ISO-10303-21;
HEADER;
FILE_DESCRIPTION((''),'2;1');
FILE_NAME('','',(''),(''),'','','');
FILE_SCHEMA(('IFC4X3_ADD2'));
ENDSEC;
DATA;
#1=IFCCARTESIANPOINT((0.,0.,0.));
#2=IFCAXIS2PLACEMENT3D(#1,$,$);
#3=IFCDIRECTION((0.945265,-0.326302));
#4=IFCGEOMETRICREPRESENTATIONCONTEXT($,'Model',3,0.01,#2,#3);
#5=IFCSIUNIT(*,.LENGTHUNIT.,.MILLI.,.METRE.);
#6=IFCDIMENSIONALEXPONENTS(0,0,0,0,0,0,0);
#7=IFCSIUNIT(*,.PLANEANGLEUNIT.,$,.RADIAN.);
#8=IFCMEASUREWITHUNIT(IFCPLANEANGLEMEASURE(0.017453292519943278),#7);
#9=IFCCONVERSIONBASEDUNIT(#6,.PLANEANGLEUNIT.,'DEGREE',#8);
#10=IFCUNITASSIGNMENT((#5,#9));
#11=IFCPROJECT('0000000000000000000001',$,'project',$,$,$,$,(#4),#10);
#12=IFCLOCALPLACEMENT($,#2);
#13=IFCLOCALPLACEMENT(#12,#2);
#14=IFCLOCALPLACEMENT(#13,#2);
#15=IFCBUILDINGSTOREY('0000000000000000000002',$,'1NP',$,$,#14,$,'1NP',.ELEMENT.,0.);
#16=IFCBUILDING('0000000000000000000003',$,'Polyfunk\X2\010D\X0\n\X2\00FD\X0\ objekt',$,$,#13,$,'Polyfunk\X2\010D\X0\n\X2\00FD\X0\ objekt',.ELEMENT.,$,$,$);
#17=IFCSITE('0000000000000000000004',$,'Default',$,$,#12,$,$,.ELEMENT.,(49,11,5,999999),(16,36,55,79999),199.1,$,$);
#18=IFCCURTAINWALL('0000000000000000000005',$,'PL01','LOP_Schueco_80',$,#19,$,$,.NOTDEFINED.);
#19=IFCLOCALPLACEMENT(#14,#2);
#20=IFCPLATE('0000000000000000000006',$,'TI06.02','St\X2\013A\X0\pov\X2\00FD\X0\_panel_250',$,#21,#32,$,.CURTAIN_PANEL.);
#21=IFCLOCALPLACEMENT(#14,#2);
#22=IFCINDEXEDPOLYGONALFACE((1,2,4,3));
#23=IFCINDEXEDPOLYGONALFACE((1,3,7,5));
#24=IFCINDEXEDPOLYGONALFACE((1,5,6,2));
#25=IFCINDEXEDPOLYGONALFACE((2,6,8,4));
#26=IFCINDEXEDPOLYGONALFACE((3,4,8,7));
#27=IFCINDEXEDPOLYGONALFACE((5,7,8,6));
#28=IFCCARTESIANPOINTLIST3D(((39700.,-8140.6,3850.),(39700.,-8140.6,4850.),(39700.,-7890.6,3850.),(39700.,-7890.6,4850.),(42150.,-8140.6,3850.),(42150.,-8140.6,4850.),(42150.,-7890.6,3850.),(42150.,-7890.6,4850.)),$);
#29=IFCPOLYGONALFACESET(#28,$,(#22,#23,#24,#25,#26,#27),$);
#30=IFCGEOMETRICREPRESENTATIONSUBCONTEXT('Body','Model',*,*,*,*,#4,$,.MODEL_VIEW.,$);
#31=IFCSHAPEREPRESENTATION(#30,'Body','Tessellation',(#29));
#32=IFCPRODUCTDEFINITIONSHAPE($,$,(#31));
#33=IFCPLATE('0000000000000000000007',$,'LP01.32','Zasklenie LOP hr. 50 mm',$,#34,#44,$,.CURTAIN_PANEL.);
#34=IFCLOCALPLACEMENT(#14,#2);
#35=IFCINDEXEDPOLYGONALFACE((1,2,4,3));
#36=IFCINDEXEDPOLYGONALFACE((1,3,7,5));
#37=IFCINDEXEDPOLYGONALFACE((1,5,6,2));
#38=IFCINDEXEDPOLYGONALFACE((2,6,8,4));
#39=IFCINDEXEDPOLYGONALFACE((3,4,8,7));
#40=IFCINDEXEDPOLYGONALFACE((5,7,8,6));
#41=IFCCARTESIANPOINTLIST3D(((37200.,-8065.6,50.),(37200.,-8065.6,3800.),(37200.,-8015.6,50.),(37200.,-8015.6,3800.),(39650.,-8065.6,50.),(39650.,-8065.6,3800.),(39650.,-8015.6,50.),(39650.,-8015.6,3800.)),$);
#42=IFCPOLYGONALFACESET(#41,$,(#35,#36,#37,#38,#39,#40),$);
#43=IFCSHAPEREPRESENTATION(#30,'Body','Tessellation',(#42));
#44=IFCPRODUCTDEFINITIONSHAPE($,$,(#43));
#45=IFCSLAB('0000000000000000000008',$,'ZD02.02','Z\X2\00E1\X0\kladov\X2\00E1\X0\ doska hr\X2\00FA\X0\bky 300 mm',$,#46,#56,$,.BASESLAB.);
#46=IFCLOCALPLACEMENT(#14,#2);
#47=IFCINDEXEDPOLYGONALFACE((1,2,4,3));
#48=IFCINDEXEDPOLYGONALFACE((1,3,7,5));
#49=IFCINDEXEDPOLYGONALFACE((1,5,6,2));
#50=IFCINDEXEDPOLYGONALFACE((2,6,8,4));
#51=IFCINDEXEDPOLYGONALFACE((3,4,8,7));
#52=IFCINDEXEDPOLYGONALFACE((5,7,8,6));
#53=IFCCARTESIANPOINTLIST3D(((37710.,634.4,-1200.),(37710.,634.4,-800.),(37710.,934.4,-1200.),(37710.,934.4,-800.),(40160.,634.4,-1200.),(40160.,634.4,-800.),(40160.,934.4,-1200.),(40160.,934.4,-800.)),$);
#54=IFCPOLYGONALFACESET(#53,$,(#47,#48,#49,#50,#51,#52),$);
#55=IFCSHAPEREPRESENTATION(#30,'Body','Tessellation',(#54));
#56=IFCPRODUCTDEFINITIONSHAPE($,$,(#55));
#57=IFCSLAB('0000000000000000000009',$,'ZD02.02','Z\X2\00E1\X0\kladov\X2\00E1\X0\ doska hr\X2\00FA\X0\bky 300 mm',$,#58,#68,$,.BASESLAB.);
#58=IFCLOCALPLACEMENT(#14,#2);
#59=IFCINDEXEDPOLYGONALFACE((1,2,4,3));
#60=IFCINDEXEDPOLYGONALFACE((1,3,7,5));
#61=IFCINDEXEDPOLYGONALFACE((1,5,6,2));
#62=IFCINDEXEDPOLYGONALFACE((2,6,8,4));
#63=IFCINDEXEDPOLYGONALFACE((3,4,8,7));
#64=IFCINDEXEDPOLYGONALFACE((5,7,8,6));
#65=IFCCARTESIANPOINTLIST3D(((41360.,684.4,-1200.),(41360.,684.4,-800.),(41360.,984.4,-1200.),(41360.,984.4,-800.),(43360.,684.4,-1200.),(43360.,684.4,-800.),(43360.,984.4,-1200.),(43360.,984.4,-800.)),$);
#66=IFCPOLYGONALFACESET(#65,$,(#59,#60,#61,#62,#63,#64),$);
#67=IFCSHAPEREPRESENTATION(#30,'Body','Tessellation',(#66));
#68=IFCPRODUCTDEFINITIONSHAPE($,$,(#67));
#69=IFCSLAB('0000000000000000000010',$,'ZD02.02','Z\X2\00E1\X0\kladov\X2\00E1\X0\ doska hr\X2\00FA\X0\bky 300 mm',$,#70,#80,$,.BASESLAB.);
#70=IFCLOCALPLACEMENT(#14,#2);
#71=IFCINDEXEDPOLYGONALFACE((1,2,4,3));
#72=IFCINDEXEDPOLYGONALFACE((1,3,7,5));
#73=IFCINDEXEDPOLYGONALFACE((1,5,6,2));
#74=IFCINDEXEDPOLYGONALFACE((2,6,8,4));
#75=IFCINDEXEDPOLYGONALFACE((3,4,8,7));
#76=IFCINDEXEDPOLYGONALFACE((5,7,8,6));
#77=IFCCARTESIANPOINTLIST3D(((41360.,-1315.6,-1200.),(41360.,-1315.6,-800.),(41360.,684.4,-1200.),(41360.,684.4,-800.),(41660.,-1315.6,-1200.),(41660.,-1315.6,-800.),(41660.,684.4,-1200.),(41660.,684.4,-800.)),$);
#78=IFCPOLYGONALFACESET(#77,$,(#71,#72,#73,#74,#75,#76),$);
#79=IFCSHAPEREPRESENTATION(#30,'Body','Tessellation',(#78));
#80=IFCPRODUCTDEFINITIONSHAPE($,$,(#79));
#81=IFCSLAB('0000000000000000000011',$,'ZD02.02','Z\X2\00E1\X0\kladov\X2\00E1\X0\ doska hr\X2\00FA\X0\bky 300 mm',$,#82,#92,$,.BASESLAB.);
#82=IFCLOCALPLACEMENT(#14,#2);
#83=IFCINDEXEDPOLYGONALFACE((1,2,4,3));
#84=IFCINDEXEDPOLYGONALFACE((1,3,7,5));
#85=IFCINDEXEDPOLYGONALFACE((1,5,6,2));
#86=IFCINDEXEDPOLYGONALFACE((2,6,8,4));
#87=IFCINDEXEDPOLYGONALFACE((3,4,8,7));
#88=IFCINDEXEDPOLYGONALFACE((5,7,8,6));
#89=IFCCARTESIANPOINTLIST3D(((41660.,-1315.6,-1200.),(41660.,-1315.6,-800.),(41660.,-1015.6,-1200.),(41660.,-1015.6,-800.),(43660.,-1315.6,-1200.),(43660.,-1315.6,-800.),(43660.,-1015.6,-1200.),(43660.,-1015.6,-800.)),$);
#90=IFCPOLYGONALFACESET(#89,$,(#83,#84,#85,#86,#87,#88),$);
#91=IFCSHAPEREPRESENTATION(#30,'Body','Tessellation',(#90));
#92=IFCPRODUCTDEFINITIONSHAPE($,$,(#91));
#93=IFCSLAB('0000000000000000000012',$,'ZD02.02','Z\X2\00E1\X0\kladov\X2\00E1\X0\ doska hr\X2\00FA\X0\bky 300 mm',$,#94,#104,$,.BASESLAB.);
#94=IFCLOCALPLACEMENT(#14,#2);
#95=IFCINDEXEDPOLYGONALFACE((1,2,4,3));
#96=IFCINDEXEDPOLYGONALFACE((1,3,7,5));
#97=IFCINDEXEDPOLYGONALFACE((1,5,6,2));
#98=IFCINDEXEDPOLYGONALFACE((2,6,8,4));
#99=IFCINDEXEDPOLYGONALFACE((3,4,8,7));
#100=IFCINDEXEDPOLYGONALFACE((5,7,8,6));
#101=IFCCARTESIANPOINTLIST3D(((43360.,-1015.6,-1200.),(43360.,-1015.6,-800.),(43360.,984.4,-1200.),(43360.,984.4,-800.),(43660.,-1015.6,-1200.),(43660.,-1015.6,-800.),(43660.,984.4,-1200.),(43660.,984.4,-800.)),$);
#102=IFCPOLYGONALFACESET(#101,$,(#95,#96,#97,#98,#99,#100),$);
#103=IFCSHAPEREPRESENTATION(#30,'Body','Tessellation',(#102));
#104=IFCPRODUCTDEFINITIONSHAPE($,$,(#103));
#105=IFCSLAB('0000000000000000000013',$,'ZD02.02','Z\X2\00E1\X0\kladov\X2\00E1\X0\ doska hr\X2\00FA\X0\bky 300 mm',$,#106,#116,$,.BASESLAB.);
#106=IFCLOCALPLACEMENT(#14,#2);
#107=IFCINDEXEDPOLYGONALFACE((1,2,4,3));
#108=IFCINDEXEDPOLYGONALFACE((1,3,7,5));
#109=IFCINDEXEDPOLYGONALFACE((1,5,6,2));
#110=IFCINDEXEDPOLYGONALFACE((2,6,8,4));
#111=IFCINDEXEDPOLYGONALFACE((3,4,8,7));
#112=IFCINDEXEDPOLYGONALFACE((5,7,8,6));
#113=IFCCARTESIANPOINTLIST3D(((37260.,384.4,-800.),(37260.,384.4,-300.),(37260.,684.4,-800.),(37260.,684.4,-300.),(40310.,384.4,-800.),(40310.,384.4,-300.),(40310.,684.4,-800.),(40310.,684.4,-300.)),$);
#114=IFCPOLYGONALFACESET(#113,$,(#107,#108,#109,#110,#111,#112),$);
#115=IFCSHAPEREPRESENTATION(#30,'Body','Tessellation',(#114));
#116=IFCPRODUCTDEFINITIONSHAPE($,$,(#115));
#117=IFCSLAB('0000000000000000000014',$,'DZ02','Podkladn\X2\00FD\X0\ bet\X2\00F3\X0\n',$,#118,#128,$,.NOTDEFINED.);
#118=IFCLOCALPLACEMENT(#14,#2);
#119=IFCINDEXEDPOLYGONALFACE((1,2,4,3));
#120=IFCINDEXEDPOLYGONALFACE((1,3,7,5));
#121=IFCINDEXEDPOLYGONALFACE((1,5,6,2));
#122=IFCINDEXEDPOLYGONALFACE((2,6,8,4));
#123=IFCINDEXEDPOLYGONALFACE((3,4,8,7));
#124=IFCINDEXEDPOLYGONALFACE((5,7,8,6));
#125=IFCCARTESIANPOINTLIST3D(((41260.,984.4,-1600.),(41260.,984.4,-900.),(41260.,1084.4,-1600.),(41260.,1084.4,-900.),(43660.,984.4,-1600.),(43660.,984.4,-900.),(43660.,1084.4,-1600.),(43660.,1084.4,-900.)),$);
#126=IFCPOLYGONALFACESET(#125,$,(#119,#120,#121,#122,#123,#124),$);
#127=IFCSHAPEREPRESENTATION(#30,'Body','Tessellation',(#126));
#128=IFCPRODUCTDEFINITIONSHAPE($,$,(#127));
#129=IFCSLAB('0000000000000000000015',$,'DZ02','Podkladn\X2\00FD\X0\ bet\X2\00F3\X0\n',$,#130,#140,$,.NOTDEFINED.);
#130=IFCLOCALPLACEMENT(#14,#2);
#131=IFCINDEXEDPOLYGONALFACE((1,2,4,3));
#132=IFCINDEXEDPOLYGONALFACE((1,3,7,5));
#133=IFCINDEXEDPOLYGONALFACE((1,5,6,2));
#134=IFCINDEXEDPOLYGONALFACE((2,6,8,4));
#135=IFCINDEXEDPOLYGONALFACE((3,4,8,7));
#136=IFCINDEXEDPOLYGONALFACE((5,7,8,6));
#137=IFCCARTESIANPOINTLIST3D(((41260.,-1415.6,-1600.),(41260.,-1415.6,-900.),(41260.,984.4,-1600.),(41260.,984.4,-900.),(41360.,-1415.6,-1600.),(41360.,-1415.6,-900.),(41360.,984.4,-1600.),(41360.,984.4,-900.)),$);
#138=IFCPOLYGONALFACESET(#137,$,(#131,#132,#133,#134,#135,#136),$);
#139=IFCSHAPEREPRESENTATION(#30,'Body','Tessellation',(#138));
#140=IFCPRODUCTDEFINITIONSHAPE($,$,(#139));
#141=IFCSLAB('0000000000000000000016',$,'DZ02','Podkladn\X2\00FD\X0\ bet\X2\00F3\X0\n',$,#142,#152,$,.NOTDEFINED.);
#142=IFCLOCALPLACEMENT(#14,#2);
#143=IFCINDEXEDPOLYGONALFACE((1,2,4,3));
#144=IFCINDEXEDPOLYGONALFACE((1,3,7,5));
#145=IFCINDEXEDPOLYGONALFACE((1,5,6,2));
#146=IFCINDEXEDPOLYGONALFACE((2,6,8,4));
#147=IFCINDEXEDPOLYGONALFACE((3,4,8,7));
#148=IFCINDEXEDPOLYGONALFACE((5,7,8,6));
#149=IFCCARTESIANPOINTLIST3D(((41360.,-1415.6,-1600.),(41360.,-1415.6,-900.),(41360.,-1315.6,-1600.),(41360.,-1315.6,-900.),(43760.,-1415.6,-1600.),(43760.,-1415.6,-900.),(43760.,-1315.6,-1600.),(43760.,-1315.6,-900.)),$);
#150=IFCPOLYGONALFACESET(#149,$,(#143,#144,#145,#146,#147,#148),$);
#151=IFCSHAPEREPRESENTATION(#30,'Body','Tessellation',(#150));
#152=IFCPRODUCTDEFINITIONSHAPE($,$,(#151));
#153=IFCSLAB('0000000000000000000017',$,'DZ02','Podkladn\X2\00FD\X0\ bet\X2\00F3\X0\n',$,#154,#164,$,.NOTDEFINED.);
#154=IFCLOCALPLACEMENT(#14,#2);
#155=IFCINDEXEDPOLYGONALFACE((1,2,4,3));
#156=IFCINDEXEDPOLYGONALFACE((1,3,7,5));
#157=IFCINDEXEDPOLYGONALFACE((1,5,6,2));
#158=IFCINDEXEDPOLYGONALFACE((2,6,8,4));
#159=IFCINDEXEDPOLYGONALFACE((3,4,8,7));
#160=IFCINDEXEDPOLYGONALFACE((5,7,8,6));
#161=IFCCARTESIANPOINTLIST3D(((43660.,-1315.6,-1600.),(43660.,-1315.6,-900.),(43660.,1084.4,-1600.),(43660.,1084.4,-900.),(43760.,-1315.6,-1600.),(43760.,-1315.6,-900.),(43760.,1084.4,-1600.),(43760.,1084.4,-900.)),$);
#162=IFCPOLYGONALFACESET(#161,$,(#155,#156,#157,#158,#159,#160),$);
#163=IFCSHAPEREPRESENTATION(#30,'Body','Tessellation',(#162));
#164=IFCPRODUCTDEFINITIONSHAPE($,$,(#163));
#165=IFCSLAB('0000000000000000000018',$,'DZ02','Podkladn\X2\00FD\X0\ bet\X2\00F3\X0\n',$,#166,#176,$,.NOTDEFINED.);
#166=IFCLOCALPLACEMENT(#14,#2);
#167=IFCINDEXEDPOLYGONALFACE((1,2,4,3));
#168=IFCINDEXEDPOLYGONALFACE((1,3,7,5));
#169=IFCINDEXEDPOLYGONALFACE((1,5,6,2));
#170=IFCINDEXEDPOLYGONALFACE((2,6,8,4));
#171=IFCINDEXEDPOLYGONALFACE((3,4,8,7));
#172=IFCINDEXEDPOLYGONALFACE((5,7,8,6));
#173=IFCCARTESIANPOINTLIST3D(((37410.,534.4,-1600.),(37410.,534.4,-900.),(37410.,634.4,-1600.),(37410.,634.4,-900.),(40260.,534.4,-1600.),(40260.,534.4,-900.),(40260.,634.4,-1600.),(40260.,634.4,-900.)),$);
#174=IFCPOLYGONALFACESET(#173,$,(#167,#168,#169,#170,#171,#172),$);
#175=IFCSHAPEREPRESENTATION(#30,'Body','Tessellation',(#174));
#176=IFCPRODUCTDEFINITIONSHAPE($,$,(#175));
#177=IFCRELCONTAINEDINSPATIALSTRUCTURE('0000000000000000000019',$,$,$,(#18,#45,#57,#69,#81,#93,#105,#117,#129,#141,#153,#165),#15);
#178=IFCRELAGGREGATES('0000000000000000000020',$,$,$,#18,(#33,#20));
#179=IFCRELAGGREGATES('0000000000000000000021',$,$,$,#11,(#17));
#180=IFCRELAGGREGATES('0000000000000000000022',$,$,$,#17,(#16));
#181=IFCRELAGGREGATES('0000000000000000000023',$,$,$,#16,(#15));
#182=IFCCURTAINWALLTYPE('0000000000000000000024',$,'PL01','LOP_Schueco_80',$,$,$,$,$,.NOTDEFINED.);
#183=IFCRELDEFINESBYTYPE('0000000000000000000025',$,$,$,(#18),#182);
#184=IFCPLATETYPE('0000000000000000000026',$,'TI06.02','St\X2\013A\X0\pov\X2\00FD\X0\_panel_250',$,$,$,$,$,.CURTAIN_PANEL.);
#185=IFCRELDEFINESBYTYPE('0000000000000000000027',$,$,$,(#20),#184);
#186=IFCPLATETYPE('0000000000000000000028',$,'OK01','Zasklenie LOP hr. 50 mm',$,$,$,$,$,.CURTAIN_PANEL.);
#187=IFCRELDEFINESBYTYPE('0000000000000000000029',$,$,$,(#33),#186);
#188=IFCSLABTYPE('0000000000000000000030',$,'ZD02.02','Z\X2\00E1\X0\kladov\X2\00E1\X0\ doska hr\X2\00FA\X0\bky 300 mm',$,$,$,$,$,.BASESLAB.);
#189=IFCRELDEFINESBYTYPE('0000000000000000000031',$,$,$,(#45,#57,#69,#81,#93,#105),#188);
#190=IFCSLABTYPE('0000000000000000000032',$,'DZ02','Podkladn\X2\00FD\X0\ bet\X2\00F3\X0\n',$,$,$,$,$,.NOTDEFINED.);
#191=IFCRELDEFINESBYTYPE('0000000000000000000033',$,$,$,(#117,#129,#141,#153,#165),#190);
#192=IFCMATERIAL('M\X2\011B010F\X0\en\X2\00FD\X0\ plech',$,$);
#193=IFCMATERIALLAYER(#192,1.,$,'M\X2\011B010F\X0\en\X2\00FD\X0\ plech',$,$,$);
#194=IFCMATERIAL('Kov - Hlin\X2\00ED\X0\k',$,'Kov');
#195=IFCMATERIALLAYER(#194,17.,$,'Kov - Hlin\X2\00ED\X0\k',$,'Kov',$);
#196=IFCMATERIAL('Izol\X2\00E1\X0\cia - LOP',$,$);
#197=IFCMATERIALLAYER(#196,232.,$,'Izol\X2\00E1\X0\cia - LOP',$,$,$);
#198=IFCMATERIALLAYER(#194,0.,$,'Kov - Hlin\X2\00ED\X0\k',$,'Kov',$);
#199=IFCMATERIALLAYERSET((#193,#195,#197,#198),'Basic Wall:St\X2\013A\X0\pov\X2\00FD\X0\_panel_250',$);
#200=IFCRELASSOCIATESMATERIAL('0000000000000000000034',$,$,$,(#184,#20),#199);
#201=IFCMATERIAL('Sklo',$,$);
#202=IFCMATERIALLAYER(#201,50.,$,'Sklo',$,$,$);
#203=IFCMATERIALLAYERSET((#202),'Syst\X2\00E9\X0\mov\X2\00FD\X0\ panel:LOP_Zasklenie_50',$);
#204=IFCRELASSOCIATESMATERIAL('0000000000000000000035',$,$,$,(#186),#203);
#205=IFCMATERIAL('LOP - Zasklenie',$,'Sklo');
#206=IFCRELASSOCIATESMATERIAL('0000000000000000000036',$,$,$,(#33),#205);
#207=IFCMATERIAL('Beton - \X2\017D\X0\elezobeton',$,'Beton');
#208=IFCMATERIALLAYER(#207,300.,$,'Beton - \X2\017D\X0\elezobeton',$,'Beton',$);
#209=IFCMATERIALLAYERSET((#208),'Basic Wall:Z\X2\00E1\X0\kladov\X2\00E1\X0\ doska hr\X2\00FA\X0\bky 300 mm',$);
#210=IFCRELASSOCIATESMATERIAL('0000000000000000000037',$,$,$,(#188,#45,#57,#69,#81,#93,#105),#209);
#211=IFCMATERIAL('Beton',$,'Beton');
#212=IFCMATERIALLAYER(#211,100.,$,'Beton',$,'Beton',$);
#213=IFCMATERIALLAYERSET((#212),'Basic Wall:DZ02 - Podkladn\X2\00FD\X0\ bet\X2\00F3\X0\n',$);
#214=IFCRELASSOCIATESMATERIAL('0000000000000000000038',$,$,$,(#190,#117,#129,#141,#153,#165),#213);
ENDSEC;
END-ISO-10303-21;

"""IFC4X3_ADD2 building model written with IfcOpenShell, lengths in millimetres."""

from ifc_helpers import new_model, entity, si_unit, converted_unit, direction, frame, frame_2d, origin, place, context, subcontext, project, spatial, rectangle, extrude, source, transform, mapped, material, layer, layer_set, layer_usage, type_object, type_shapes, element, aggregate, save


model = new_model("IFC4X3_ADD2")

# Units and contexts
model_context = context("Model", 3, precision=0.01, world=origin(), true_north=direction((0.945265, -0.326302)))
body_context = subcontext(model_context, "Body", "Model", "MODEL_VIEW")
ifc_project = project(units=[si_unit("LENGTHUNIT", "METRE", prefix="MILLI"), converted_unit("PLANEANGLEUNIT", "DEGREE", entity("IfcPlaneAngleMeasure", 0.017453292519943278), si_unit("PLANEANGLEUNIT", "RADIAN"), dimensions=[0, 0, 0, 0, 0, 0, 0])], contexts=[model_context])

# Site, building, storey
site_placement = place(None, origin())
site = spatial("IfcSite", under=ifc_project, at=site_placement, Name="Default", CompositionType="ELEMENT", RefLatitude=(49, 11, 5, 999999), RefLongitude=(16, 36, 55, 79999), RefElevation=199.1)
building_placement = place(site_placement, origin())
building = spatial("IfcBuilding", under=site, at=building_placement, Name="Polyfunkčný objekt", LongName="Polyfunkčný objekt", CompositionType="ELEMENT")
storey_placement = place(building_placement, origin())
storey = spatial("IfcBuildingStorey", under=building, at=storey_placement, Name="1NP", LongName="1NP", CompositionType="ELEMENT", Elevation=0.0)

# Curtain wall, plates
curtain_wall_type = type_object("IfcCurtainWallType", Name="PL01", Description="LOP_Schueco_80", PredefinedType="NOTDEFINED")
curtain_wall_placement = place(storey_placement, origin())
curtain_wall = element("IfcCurtainWall", 1, at=curtain_wall_placement, inside=storey, type_object=curtain_wall_type, Name="PL01", Description="LOP_Schueco_80", PredefinedType="NOTDEFINED")
ifc_material_1 = material(Name="Měďený plech")
ifc_layer_1 = layer(ifc_material_1, 1.0, Name="Měďený plech")
ifc_material_2 = material(Name="Kov - Hliník", Category="Kov")
ifc_layer_2 = layer(ifc_material_2, 17.0, Name="Kov - Hliník", Category="Kov")
ifc_material_3 = material(Name="Izolácia - LOP")
ifc_layer_3 = layer(ifc_material_3, 232.0, Name="Izolácia - LOP")
ifc_layer_4 = layer(ifc_material_2, 0.0, Name="Kov - Hliník", Category="Kov")
ifc_layer_set_1 = layer_set([ifc_layer_1, ifc_layer_2, ifc_layer_3, ifc_layer_4], Name="Basic Wall:Stĺpový_panel_250")
ifc_layer_usage = layer_usage(ifc_layer_set_1, "AXIS2", "POSITIVE", -125.0)
plate_type_1 = type_object("IfcPlateType", Name="TI06.02", Description="Stĺpový_panel_250", PredefinedType="CURTAIN_PANEL", material=ifc_layer_set_1)
plate_1_placement = place(storey_placement, frame((39700.0, -8015.6, 3850.0)))
plate_1 = element("IfcPlate", 2, at=plate_1_placement, type_object=plate_type_1, material=ifc_layer_usage, Name="TI06.02", Description="Stĺpový_panel_250", PredefinedType="CURTAIN_PANEL", context=body_context, shape_type="SweptSolid", body=[
    extrude(rectangle(XDim=250.0, YDim=2450.0, at=frame_2d((0.0, 0.0), x_axis=(1.0, 0.0))), frame((1225.0, 0.0, 0.0), z_axis=(0.0, 0.0, 1.0), x_axis=(0.0, 1.0, 0.0)), (0.0, 0.0, 1.0), 1000.0),
])
ifc_material_4 = material(Name="LOP - Zasklenie", Category="Sklo")
ifc_material_5 = material(Name="Sklo")
ifc_layer_5 = layer(ifc_material_5, 50.0, Name="Sklo")
ifc_layer_set_2 = layer_set([ifc_layer_5], Name="Systémový panel:LOP_Zasklenie_50")
plate_type_2 = type_object("IfcPlateType", Name="OK01", Description="Zasklenie LOP hr. 50 mm", PredefinedType="CURTAIN_PANEL", material=ifc_layer_set_2)
shared_shape_1 = source(origin(), body_context, "Body", "SweptSolid", [
    extrude(rectangle(XDim=3750.0, YDim=2450.0, at=frame_2d((-331.2, 0.0), x_axis=(1.0, 0.0))), frame((0.0, -50.0, 2206.2), z_axis=(0.0, 1.0, 0.0), x_axis=(0.0, 0.0, 1.0)), (0.0, 0.0, 1.0), 50.0),
])
type_shapes(plate_type_2, [shared_shape_1])
plate_2_placement = place(curtain_wall_placement, frame((38425.0, -8015.6, 50.0)))
plate_2 = element("IfcPlate", 3, at=plate_2_placement, type_object=plate_type_2, material=ifc_material_4, Name="LP01.32", Description="Zasklenie LOP hr. 50 mm", PredefinedType="CURTAIN_PANEL", context=body_context, shape_type="MappedRepresentation", body=[
    mapped(shared_shape_1, transform((0.0, 0.0, 0.0), scale=1.0)),
])
aggregate(curtain_wall, [plate_2, plate_1])

# Slabs
ifc_material_6 = material(Name="Beton - Železobeton", Category="Beton")
ifc_layer_6 = layer(ifc_material_6, 300.0, Name="Beton - Železobeton", Category="Beton")
ifc_layer_set_3 = layer_set([ifc_layer_6], Name="Basic Wall:Základová doska hrúbky 300 mm")
slab_type_1 = type_object("IfcSlabType", Name="ZD02.02", Description="Základová doska hrúbky 300 mm", PredefinedType="BASESLAB", material=ifc_layer_set_3)
slab_1_placement = place(storey_placement, frame((40160.0, 784.4, -1200.0), z_axis=(0.0, 0.0, 1.0), x_axis=(-1.0, 0.0, 0.0)))
element("IfcSlab", 4, at=slab_1_placement, inside=storey, type_object=slab_type_1, material=ifc_layer_set_3, Name="ZD02.02", Description="Základová doska hrúbky 300 mm", PredefinedType="BASESLAB", context=body_context, shape_type="SweptSolid", body=[
    extrude(rectangle(XDim=2450.0, YDim=300.0, at=frame_2d((1225.0, 0.0), x_axis=(-1.0, 0.0))), origin(), (0.0, 0.0, 1.0), 400.0),
])
slab_2_placement = place(storey_placement, frame((41360.0, 834.4, -1200.0)))
element("IfcSlab", 5, at=slab_2_placement, inside=storey, type_object=slab_type_1, material=ifc_layer_set_3, Name="ZD02.02", Description="Základová doska hrúbky 300 mm", PredefinedType="BASESLAB", context=body_context, shape_type="SweptSolid", body=[
    extrude(rectangle(XDim=2000.0, YDim=300.0, at=frame_2d((1000.0, 0.0), x_axis=(-1.0, 0.0))), origin(), (0.0, 0.0, 1.0), 400.0),
])
slab_3_placement = place(storey_placement, frame((41510.0, -1315.6, -1200.0), z_axis=(0.0, 0.0, 1.0), x_axis=(0.0, 1.0, 0.0)))
element("IfcSlab", 6, at=slab_3_placement, inside=storey, type_object=slab_type_1, material=ifc_layer_set_3, Name="ZD02.02", Description="Základová doska hrúbky 300 mm", PredefinedType="BASESLAB", context=body_context, shape_type="SweptSolid", body=[
    extrude(rectangle(XDim=2000.0, YDim=300.0, at=frame_2d((1000.0, 0.0), x_axis=(-1.0, 0.0))), origin(), (0.0, 0.0, 1.0), 400.0),
])
slab_4_placement = place(storey_placement, frame((43660.0, -1165.6, -1200.0), z_axis=(0.0, 0.0, 1.0), x_axis=(-1.0, 0.0, 0.0)))
element("IfcSlab", 7, at=slab_4_placement, inside=storey, type_object=slab_type_1, material=ifc_layer_set_3, Name="ZD02.02", Description="Základová doska hrúbky 300 mm", PredefinedType="BASESLAB", context=body_context, shape_type="SweptSolid", body=[
    extrude(rectangle(XDim=2000.0, YDim=300.0, at=frame_2d((1000.0, 0.0), x_axis=(-1.0, 0.0))), origin(), (0.0, 0.0, 1.0), 400.0),
])
slab_5_placement = place(storey_placement, frame((43510.0, 984.4, -1200.0), z_axis=(0.0, 0.0, 1.0), x_axis=(0.0, -1.0, 0.0)))
element("IfcSlab", 8, at=slab_5_placement, inside=storey, type_object=slab_type_1, material=ifc_layer_set_3, Name="ZD02.02", Description="Základová doska hrúbky 300 mm", PredefinedType="BASESLAB", context=body_context, shape_type="SweptSolid", body=[
    extrude(rectangle(XDim=2000.0, YDim=300.0, at=frame_2d((1000.0, 0.0), x_axis=(-1.0, 0.0))), origin(), (0.0, 0.0, 1.0), 400.0),
])
slab_6_placement = place(storey_placement, frame((40310.0, 534.4, -800.0), z_axis=(0.0, 0.0, 1.0), x_axis=(-1.0, 0.0, 0.0)))
element("IfcSlab", 9, at=slab_6_placement, inside=storey, type_object=slab_type_1, material=ifc_layer_set_3, Name="ZD02.02", Description="Základová doska hrúbky 300 mm", PredefinedType="BASESLAB", context=body_context, shape_type="SweptSolid", body=[
    extrude(rectangle(XDim=3050.0, YDim=300.0, at=frame_2d((1525.0, 0.0), x_axis=(-1.0, 0.0))), origin(), (0.0, 0.0, 1.0), 500.0),
])
ifc_material_7 = material(Name="Beton", Category="Beton")
ifc_layer_7 = layer(ifc_material_7, 100.0, Name="Beton", Category="Beton")
ifc_layer_set_4 = layer_set([ifc_layer_7], Name="Basic Wall:DZ02 - Podkladný betón")
slab_type_2 = type_object("IfcSlabType", Name="DZ02", Description="Podkladný betón", PredefinedType="NOTDEFINED", material=ifc_layer_set_4)
slab_7_placement = place(storey_placement, frame((41260.0, 1034.4, -1600.0)))
element("IfcSlab", 10, at=slab_7_placement, inside=storey, type_object=slab_type_2, material=ifc_layer_set_4, Name="DZ02", Description="Podkladný betón", PredefinedType="NOTDEFINED", context=body_context, shape_type="SweptSolid", body=[
    extrude(rectangle(XDim=2400.0, YDim=100.0, at=frame_2d((1200.0, 0.0), x_axis=(-1.0, 0.0))), origin(), (0.0, 0.0, 1.0), 700.0),
])
slab_8_placement = place(storey_placement, frame((41310.0, -1415.6, -1600.0), z_axis=(0.0, 0.0, 1.0), x_axis=(0.0, 1.0, 0.0)))
element("IfcSlab", 11, at=slab_8_placement, inside=storey, type_object=slab_type_2, material=ifc_layer_set_4, Name="DZ02", Description="Podkladný betón", PredefinedType="NOTDEFINED", context=body_context, shape_type="SweptSolid", body=[
    extrude(rectangle(XDim=2400.0, YDim=100.0, at=frame_2d((1200.0, 0.0), x_axis=(-1.0, 0.0))), origin(), (0.0, 0.0, 1.0), 700.0),
])
slab_9_placement = place(storey_placement, frame((43760.0, -1365.6, -1600.0), z_axis=(0.0, 0.0, 1.0), x_axis=(-1.0, 0.0, 0.0)))
element("IfcSlab", 12, at=slab_9_placement, inside=storey, type_object=slab_type_2, material=ifc_layer_set_4, Name="DZ02", Description="Podkladný betón", PredefinedType="NOTDEFINED", context=body_context, shape_type="SweptSolid", body=[
    extrude(rectangle(XDim=2400.0, YDim=100.0, at=frame_2d((1200.0, 0.0), x_axis=(-1.0, 0.0))), origin(), (0.0, 0.0, 1.0), 700.0),
])
slab_10_placement = place(storey_placement, frame((43710.0, 1084.4, -1600.0), z_axis=(0.0, 0.0, 1.0), x_axis=(0.0, -1.0, 0.0)))
element("IfcSlab", 13, at=slab_10_placement, inside=storey, type_object=slab_type_2, material=ifc_layer_set_4, Name="DZ02", Description="Podkladný betón", PredefinedType="NOTDEFINED", context=body_context, shape_type="SweptSolid", body=[
    extrude(rectangle(XDim=2400.0, YDim=100.0, at=frame_2d((1200.0, 0.0), x_axis=(-1.0, 0.0))), origin(), (0.0, 0.0, 1.0), 700.0),
])
slab_11_placement = place(storey_placement, frame((40260.0, 584.4, -1600.0), z_axis=(0.0, 0.0, 1.0), x_axis=(-1.0, 0.0, 0.0)))
element("IfcSlab", 14, at=slab_11_placement, inside=storey, type_object=slab_type_2, material=ifc_layer_set_4, Name="DZ02", Description="Podkladný betón", PredefinedType="NOTDEFINED", context=body_context, shape_type="SweptSolid", body=[
    extrude(rectangle(XDim=2850.0, YDim=100.0, at=frame_2d((1425.0, 0.0), x_axis=(-1.0, 0.0))), origin(), (0.0, 0.0, 1.0), 700.0),
])

save(model, "model.ifc")
